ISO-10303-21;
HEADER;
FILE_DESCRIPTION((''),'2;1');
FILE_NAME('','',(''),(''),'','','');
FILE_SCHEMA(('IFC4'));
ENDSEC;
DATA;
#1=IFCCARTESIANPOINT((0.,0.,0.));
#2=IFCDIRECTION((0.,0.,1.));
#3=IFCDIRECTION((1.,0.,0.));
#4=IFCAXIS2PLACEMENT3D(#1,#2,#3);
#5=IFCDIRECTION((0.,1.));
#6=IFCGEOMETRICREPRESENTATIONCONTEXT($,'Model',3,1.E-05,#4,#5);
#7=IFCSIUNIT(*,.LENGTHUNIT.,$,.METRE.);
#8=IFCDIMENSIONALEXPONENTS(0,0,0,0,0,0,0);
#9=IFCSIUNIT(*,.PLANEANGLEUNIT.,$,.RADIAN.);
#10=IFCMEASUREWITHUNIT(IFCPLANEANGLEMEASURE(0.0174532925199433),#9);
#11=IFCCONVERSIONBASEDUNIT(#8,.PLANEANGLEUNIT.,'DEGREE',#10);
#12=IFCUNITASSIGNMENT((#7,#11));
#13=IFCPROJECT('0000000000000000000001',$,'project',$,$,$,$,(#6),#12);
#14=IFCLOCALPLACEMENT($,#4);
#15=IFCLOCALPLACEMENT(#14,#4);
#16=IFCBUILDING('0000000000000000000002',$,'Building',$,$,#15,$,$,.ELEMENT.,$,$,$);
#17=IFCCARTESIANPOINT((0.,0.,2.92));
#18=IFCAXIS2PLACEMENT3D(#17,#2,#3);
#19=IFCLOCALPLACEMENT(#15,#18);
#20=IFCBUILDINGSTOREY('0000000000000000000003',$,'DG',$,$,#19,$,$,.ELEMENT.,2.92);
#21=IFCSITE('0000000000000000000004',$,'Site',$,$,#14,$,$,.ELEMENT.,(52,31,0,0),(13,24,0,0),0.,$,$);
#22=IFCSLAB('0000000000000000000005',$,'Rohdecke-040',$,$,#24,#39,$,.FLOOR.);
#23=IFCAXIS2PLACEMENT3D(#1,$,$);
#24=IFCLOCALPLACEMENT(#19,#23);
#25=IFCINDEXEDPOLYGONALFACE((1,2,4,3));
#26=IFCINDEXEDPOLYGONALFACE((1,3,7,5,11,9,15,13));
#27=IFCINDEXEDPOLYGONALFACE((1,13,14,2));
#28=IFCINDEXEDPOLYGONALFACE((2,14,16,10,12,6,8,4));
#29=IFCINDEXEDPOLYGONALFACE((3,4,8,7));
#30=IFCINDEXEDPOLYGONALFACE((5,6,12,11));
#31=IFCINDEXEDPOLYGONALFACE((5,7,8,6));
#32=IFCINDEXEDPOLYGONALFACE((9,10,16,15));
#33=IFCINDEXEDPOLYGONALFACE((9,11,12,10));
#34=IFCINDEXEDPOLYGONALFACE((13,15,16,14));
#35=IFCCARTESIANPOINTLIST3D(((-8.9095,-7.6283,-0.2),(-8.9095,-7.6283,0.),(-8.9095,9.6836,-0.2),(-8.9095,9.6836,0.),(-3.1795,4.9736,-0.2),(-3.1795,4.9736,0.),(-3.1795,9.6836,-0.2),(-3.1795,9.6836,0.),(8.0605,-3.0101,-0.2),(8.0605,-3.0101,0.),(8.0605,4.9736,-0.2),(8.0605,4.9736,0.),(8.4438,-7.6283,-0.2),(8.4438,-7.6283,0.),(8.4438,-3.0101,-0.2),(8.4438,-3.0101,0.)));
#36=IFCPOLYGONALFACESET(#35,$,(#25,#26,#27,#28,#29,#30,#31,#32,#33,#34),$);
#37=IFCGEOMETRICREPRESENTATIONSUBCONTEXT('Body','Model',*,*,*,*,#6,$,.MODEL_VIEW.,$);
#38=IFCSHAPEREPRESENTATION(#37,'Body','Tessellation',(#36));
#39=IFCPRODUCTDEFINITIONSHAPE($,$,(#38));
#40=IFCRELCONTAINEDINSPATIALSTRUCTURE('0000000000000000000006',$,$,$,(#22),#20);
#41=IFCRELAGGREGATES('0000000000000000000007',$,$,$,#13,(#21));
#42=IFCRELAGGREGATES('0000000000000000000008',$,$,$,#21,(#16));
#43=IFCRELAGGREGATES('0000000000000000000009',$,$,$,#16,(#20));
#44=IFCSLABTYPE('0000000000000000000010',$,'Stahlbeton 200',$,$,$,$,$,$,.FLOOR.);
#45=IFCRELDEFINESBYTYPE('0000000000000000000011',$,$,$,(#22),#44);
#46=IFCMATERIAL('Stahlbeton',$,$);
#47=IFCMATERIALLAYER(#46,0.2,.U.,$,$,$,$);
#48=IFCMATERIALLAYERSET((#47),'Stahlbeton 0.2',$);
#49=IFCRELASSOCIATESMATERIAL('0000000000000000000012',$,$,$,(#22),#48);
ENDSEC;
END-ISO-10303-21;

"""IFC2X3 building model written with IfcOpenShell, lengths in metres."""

from ifc_helpers import new_model, entity, si_unit, converted_unit, direction, frame, origin_with_axes, place, context, subcontext, project, spatial, polyline, outline, extrude, material, layer, layer_set, layer_usage, type_object, element, save


model = new_model("IFC2X3")

# Units and contexts
model_context = context("Model", 3, precision=1e-05, world=origin_with_axes(), true_north=direction((0.0, 1.0)))
body_context = subcontext(model_context, "Body", "Model", "MODEL_VIEW")
ifc_project = project(units=[si_unit("LENGTHUNIT", "METRE"), converted_unit("PLANEANGLEUNIT", "DEGREE", entity("IfcPlaneAngleMeasure", 0.0174532925199433), si_unit("PLANEANGLEUNIT", "RADIAN"), dimensions=[0, 0, 0, 0, 0, 0, 0])], contexts=[model_context])

# Site, building, storey
site_placement = place(None, origin_with_axes())
site = spatial("IfcSite", under=ifc_project, at=site_placement, Name="Site", CompositionType="ELEMENT", RefLatitude=(52, 31, 0, 0), RefLongitude=(13, 24, 0, 0), RefElevation=0.0)
building_placement = place(site_placement, origin_with_axes())
building = spatial("IfcBuilding", under=site, at=building_placement, Name="Building", CompositionType="ELEMENT")
storey_placement = place(building_placement, frame((0.0, 0.0, 2.92), z_axis=(0.0, 0.0, 1.0), x_axis=(1.0, 0.0, 0.0)))
storey = spatial("IfcBuildingStorey", under=building, at=storey_placement, Name="DG", CompositionType="ELEMENT", Elevation=2.92)

# Slab
ifc_material = material(Name="Stahlbeton")
ifc_layer = layer(ifc_material, 0.2, ventilated="UNKNOWN")
ifc_layer_set = layer_set([ifc_layer], Name="Stahlbeton 0.2")
ifc_layer_usage_1 = layer_usage(ifc_layer_set, "AXIS3", "NEGATIVE", 0.2)
slab_type_1 = type_object("IfcSlabType", Name="Stahlbeton 200", PredefinedType="FLOOR")
slab_1_placement = place(storey_placement, frame((8.0605, 4.9736, 0.0), z_axis=(0.0, 0.0, 1.0), x_axis=(1.0, 0.0, 0.0)))
element("IfcSlab", 1, at=slab_1_placement, inside=storey, type_object=slab_type_1, material=ifc_layer_usage_1, Name="Rohdecke-040", PredefinedType="FLOOR", context=body_context, shape_type="SweptSolid", body=[
    extrude(outline(polyline([(0.0, 0.0), (-11.24, 0.0), (-11.24, 4.71), (-16.97, 4.71), (-16.97, -12.6019), (0.3833, -12.6019), (0.3833, -7.9838), (0.0, -7.9838), (0.0, 0.0)])), frame((0.0, 0.0, -0.2), z_axis=(0.0, 0.0, 1.0), x_axis=(1.0, 0.0, 0.0)), (0.0, 0.0, 1.0), 0.2),
])

save(model, "model.ifc")
